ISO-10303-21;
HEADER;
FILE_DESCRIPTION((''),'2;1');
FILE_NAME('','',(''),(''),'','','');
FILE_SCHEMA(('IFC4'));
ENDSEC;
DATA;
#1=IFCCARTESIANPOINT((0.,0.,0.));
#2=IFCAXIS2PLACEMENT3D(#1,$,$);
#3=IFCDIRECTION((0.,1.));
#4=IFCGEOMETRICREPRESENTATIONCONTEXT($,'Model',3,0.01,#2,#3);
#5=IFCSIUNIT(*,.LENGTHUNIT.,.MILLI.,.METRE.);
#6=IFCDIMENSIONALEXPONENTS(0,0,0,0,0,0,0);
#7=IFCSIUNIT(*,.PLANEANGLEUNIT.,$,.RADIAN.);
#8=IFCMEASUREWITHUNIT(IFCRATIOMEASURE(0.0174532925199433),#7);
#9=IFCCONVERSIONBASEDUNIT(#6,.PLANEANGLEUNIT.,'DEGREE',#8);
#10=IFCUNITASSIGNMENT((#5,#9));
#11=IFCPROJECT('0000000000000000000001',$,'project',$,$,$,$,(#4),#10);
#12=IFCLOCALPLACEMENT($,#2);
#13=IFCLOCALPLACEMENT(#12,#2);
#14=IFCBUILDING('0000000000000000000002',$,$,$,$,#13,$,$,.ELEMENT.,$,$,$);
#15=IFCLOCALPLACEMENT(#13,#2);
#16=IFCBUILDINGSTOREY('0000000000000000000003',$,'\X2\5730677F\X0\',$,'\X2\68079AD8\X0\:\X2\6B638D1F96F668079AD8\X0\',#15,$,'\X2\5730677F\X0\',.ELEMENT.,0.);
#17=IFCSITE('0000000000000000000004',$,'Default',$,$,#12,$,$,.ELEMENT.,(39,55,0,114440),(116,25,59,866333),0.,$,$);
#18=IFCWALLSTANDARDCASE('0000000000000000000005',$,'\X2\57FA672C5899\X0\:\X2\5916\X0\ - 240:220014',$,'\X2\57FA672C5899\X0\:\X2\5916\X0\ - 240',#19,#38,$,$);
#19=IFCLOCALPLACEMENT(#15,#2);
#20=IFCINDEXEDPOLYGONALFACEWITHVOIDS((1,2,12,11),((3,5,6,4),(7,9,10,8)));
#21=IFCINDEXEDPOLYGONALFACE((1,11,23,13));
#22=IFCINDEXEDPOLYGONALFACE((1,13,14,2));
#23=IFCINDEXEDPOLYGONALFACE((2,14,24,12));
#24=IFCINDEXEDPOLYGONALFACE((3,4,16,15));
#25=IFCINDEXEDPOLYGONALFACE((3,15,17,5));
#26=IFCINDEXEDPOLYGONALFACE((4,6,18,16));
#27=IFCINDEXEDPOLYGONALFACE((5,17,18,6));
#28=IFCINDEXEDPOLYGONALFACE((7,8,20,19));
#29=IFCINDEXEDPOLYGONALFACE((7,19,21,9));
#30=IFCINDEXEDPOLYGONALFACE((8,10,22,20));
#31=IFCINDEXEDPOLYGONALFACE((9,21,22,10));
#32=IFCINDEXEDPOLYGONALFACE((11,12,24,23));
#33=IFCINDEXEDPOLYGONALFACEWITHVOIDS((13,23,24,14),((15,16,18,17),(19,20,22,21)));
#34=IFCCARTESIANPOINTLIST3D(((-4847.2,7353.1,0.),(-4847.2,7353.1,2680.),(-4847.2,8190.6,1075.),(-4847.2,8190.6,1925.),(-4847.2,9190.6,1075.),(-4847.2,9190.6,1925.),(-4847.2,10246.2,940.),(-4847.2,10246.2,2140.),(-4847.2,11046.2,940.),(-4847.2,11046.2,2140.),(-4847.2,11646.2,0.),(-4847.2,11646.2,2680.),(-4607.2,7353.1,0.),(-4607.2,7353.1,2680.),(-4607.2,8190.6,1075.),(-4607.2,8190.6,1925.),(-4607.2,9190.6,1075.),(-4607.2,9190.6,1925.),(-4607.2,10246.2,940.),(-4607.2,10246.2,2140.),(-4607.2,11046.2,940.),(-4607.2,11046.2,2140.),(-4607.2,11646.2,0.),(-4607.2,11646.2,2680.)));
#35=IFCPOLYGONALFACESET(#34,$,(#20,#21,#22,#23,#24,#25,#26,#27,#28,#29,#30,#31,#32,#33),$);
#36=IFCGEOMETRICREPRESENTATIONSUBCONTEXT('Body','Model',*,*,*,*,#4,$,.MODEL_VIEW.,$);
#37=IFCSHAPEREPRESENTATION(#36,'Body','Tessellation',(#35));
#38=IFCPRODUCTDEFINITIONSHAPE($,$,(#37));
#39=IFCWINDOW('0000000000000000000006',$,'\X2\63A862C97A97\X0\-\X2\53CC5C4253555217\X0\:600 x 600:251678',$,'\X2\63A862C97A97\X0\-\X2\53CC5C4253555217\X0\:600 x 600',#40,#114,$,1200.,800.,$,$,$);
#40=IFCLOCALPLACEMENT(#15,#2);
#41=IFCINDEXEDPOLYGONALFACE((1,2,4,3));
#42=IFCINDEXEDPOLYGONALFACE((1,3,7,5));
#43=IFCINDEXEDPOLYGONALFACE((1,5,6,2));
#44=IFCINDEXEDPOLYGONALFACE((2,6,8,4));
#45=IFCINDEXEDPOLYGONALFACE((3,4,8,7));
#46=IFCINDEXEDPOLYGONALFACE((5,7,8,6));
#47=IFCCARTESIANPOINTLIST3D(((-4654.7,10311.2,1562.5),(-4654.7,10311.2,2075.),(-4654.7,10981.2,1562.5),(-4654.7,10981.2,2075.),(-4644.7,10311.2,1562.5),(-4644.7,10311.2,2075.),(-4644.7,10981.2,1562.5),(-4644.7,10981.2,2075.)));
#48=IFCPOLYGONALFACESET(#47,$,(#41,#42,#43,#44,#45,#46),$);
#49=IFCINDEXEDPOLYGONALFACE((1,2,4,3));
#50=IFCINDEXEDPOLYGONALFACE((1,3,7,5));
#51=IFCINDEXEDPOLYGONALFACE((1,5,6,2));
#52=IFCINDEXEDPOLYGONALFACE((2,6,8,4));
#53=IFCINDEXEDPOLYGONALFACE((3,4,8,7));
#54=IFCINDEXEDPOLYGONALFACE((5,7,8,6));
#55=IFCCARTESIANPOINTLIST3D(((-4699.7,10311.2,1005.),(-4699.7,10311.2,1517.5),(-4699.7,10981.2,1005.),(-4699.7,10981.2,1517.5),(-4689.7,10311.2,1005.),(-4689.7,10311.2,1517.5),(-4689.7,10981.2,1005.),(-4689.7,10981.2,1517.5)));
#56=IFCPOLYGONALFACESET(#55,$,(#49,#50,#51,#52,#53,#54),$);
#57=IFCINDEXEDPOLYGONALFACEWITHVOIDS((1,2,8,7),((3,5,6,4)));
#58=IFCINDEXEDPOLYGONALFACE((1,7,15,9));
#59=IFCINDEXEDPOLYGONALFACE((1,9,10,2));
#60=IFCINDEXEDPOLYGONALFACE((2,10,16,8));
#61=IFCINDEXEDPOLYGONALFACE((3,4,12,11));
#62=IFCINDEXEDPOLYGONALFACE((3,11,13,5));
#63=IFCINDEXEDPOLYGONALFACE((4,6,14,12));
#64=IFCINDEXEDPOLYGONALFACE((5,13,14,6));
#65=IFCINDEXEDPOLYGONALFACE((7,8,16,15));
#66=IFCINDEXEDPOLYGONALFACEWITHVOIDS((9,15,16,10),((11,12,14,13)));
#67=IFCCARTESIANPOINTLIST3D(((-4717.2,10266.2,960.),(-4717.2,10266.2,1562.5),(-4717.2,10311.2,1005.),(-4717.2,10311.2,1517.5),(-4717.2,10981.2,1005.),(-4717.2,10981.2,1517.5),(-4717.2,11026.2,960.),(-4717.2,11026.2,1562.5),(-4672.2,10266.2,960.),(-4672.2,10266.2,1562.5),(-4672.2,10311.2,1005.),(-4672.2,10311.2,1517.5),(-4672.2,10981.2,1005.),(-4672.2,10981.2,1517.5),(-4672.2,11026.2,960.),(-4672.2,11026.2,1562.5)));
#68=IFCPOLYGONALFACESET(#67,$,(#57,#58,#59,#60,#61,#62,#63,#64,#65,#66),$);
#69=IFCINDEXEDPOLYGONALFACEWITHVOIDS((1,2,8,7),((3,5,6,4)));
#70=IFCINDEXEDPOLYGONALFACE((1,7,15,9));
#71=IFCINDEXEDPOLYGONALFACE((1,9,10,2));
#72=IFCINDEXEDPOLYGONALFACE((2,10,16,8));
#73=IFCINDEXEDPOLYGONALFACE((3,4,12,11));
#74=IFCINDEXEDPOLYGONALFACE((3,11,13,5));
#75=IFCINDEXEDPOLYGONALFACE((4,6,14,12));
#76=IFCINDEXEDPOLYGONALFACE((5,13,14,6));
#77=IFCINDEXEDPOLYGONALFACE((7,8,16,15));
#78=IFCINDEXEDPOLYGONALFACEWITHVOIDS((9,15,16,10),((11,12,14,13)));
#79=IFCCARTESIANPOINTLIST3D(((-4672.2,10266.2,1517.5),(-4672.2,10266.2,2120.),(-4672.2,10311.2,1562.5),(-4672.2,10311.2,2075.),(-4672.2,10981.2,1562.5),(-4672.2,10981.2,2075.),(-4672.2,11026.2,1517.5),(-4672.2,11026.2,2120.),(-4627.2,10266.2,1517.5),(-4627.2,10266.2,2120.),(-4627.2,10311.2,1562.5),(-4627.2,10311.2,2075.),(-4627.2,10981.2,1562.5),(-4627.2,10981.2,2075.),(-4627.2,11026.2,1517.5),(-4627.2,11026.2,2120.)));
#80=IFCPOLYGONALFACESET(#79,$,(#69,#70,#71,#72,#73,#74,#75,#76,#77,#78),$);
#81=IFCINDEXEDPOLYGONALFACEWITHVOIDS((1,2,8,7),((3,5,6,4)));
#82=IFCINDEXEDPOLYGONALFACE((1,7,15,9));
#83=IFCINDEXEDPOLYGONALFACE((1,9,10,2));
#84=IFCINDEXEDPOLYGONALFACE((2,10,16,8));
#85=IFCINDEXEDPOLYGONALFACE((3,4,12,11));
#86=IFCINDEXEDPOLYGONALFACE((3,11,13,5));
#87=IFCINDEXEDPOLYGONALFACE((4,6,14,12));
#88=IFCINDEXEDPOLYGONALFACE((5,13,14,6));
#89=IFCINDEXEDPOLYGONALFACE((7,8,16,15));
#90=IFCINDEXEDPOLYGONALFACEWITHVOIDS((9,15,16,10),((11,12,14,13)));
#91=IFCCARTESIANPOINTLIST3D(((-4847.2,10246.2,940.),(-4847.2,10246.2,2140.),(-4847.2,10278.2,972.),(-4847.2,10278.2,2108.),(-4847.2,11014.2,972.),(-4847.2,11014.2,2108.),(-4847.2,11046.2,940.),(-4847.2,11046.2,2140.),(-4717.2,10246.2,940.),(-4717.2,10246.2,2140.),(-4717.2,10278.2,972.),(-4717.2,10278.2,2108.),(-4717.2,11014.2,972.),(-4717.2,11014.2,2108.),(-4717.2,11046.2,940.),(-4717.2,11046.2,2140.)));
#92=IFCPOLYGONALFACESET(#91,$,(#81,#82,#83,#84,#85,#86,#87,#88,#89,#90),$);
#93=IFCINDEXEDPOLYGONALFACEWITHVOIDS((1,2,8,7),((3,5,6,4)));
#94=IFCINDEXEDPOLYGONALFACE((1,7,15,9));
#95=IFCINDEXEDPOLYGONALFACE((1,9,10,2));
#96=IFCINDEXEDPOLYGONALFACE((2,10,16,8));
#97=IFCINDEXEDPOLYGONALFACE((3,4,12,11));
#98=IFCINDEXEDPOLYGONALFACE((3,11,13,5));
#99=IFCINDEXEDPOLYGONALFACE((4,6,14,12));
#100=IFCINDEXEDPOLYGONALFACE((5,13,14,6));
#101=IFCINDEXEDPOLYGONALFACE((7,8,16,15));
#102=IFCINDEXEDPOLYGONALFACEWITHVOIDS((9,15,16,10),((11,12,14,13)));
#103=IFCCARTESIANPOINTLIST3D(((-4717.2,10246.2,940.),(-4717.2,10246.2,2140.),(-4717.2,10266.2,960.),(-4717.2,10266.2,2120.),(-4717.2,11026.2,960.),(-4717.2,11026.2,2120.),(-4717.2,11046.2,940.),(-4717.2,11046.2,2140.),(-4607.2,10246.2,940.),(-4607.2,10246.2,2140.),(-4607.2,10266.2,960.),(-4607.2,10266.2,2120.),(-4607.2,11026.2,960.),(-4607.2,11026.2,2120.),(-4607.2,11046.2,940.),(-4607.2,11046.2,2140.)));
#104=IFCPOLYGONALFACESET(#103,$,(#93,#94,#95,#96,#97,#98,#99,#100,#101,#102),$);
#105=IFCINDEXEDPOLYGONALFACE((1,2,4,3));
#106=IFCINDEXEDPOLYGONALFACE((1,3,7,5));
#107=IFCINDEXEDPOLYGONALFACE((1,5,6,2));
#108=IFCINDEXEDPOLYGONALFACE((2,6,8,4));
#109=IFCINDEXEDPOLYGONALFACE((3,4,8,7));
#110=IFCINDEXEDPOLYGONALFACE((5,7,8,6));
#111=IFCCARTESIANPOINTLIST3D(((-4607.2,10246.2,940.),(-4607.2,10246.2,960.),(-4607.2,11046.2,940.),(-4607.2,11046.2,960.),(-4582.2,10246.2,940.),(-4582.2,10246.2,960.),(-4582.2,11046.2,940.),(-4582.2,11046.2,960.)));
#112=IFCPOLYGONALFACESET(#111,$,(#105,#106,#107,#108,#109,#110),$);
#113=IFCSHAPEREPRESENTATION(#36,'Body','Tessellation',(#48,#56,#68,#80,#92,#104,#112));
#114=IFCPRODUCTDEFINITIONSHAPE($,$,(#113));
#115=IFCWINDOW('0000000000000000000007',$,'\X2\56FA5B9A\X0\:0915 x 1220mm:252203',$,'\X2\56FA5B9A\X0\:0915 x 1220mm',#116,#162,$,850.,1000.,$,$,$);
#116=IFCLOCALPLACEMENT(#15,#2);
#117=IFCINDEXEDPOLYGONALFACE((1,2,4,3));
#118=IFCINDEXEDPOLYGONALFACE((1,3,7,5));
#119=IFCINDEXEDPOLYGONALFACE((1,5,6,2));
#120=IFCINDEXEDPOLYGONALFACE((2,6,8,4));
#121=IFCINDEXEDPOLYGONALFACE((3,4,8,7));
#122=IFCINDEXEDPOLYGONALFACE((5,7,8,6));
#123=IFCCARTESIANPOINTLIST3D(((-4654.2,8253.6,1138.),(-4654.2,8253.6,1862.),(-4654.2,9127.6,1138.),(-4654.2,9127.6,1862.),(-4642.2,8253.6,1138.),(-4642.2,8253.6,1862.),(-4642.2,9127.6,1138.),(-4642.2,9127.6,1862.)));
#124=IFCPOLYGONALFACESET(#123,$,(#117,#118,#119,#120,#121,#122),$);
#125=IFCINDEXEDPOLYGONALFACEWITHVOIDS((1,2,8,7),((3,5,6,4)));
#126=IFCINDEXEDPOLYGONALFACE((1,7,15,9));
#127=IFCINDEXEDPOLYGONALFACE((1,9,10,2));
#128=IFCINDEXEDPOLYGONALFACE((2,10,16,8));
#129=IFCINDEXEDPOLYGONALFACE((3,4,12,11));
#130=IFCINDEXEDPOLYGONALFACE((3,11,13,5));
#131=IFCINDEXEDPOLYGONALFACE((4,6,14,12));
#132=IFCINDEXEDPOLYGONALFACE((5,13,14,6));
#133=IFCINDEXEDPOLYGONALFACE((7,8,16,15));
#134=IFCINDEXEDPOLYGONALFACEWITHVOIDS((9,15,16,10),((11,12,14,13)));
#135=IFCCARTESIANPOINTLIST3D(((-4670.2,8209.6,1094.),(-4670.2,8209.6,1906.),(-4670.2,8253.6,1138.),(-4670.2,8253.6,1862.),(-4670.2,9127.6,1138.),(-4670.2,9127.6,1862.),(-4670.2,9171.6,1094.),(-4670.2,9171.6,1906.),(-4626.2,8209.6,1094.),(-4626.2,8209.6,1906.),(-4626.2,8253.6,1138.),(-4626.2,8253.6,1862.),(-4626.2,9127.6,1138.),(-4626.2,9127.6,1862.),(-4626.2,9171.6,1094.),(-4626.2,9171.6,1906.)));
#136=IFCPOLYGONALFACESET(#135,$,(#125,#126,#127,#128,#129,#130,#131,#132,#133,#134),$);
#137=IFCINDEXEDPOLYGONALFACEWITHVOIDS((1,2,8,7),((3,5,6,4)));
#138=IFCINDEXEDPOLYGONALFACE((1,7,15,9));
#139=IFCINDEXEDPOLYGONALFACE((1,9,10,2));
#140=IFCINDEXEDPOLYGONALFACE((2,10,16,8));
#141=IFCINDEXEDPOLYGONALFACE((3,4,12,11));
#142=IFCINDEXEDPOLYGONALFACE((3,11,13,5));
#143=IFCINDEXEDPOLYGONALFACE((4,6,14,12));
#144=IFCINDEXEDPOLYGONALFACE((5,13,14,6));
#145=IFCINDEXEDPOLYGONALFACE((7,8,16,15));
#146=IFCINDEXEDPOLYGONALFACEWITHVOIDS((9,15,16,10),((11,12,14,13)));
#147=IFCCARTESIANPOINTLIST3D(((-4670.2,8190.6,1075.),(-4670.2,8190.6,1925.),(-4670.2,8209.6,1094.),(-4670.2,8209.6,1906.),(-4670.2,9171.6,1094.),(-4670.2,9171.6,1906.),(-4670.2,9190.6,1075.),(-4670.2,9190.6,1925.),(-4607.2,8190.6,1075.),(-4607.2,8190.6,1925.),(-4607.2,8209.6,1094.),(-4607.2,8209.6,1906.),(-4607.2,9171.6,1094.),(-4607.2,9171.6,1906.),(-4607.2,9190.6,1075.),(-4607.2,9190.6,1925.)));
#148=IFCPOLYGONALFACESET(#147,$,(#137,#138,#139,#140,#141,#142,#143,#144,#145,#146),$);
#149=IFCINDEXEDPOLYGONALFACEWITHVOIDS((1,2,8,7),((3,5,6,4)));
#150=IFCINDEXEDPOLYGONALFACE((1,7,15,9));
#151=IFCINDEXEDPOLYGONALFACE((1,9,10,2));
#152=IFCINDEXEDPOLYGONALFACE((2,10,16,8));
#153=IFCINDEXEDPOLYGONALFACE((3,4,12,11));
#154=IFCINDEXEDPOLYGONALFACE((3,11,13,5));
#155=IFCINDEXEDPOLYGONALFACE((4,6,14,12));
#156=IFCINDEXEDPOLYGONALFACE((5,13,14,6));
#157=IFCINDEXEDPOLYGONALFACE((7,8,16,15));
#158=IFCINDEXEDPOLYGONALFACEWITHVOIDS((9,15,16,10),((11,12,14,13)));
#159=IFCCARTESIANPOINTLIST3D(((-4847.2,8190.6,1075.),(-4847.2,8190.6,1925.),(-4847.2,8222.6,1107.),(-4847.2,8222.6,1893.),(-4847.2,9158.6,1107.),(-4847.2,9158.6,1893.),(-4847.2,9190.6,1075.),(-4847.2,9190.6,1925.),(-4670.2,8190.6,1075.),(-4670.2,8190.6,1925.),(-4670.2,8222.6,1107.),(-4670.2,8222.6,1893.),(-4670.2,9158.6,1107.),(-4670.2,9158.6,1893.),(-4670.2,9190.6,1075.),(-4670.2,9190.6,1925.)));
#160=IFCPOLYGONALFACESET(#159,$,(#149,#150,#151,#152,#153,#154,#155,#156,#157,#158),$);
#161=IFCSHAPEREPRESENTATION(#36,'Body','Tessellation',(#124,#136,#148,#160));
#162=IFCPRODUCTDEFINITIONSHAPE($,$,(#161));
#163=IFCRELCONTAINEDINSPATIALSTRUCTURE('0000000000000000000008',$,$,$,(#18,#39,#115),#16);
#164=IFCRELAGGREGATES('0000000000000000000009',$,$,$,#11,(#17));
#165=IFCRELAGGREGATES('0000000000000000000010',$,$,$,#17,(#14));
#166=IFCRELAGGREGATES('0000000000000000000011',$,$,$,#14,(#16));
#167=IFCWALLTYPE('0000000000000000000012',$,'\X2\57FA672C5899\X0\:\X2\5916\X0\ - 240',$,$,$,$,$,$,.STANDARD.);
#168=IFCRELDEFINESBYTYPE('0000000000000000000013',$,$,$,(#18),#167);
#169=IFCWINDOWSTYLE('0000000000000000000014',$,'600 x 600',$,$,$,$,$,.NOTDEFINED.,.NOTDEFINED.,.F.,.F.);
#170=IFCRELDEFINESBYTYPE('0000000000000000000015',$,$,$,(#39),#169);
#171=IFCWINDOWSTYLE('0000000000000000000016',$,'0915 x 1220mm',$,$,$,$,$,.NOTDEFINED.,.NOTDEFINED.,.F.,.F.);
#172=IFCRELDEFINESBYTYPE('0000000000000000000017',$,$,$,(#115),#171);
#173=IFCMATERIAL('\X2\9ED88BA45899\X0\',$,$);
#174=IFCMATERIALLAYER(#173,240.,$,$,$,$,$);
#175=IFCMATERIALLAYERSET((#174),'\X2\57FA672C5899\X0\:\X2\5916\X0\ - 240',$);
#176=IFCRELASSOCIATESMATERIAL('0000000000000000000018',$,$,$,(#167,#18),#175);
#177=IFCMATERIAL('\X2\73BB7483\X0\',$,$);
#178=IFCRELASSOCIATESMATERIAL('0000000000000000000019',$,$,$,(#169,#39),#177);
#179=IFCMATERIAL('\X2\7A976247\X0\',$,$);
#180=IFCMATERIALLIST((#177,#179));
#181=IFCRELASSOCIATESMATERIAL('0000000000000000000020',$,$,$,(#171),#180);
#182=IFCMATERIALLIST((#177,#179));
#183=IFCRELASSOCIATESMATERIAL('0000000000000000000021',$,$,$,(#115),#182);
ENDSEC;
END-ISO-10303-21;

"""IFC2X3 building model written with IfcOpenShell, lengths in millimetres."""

from ifc_helpers import new_model, entity, si_unit, converted_unit, direction, frame, frame_2d, origin, origin_2d_with_axis, place, context, subcontext, project, spatial, polyline, rectangle, outline, extrude, source, transform, mapped, material, material_list, layer, layer_set, layer_usage, type_object, type_shapes, element, fill, save


model = new_model("IFC2X3")

# Units and contexts
model_context = context("Model", 3, precision=0.01, world=origin(), true_north=direction((0.0, 1.0)))
body_context = subcontext(model_context, "Body", "Model", "MODEL_VIEW")
ifc_project = project(units=[si_unit("LENGTHUNIT", "METRE", prefix="MILLI"), converted_unit("PLANEANGLEUNIT", "DEGREE", entity("IfcRatioMeasure", 0.0174532925199433), si_unit("PLANEANGLEUNIT", "RADIAN"), dimensions=[0, 0, 0, 0, 0, 0, 0])], contexts=[model_context])

# Site, building, storey
site_placement = place(None, origin())
site = spatial("IfcSite", under=ifc_project, at=site_placement, Name="Default", CompositionType="ELEMENT", RefLatitude=(39, 55, 0, 114440), RefLongitude=(116, 25, 59, 866333), RefElevation=0.0)
building_placement = place(site_placement, origin())
building = spatial("IfcBuilding", under=site, at=building_placement, CompositionType="ELEMENT")
storey_placement = place(building_placement, origin())
storey = spatial("IfcBuildingStorey", under=building, at=storey_placement, Name="地板", ObjectType="标高:正负零标高", LongName="地板", CompositionType="ELEMENT", Elevation=0.0)

# Shared definitions
ifc_material_1 = material(Name="默认墙")
ifc_layer_1 = layer(ifc_material_1, 240.0)
ifc_layer_set_1 = layer_set([ifc_layer_1], Name="基本墙:外 - 240")
wall_type_1 = type_object("IfcWallType", Name="基本墙:外 - 240", PredefinedType="STANDARD", material=ifc_layer_set_1)
ifc_material_2 = material(Name="玻璃")
ifc_material_3 = material(Name="窗扇")

# Wall, openings, windows
ifc_layer_usage_1 = layer_usage(ifc_layer_set_1, "AXIS2", "NEGATIVE", 120.0)
wall_1_placement = place(storey_placement, frame((-4727.2, 7353.1, 0.0), z_axis=(0.0, 0.0, 1.0), x_axis=(0.0, 1.0, 0.0)))
wall_1 = element("IfcWallStandardCase", 1, at=wall_1_placement, inside=storey, type_object=wall_type_1, material=ifc_layer_usage_1, Name="基本墙:外 - 240:220014", ObjectType="基本墙:外 - 240", context=body_context, shape_type="SweptSolid", body=[
    extrude(rectangle(XDim=4293.1, YDim=240.0, at=frame_2d((2146.5, 0.0), x_axis=(-1.0, 0.0))), origin(), (0.0, 0.0, 1.0), 2680.0),
])
opening_1_placement = place(wall_1_placement, frame((3693.1, 120.0, 940.0)))
opening_1 = element("IfcOpeningElement", 2, at=opening_1_placement, cuts=wall_1, ObjectType="Opening", context=body_context, shape_type="SweptSolid", body=[
    extrude(rectangle(XDim=1200.0, YDim=800.0, at=frame_2d((600.0, 400.0), x_axis=(-1.0, 0.0))), frame((0.0, 0.0, 0.0), z_axis=(0.0, -1.0, 0.0), x_axis=(0.0, 0.0, 1.0)), (0.0, 0.0, 1.0), 240.0),
])
opening_2_placement = place(wall_1_placement, frame((1837.5, 120.0, 1075.0)))
opening_2 = element("IfcOpeningElement", 3, at=opening_2_placement, cuts=wall_1, ObjectType="Opening", context=body_context, shape_type="SweptSolid", body=[
    extrude(rectangle(XDim=850.0, YDim=1000.0, at=frame_2d((425.0, 500.0), x_axis=(1.0, 0.0))), frame((0.0, 0.0, 0.0), z_axis=(0.0, -1.0, 0.0), x_axis=(0.0, 0.0, 1.0)), (0.0, 0.0, 1.0), 240.0),
])
window_style_1 = type_object("IfcWindowStyle", Name="600 x 600", ConstructionType="NOTDEFINED", OperationType="NOTDEFINED", ParameterTakesPrecedence=False, Sizeable=False, material=ifc_material_2)
shared_shape_1 = source(origin(), body_context, "Body", "SweptSolid", [
    extrude(rectangle(XDim=10.0, YDim=670.0, at=origin_2d_with_axis()), frame((400.0, 197.5, 622.5), z_axis=(0.0, 0.0, 1.0), x_axis=(0.0, -1.0, 0.0)), (0.0, 0.0, 1.0), 512.5),
    extrude(rectangle(XDim=10.0, YDim=670.0, at=origin_2d_with_axis()), frame((400.0, 152.5, 65.0), z_axis=(0.0, 0.0, 1.0), x_axis=(0.0, -1.0, 0.0)), (0.0, 0.0, 1.0), 512.5),
    extrude(outline(polyline([(-380.0, -301.2), (380.0, -301.2), (380.0, 301.2), (-380.0, 301.2), (-380.0, -301.2)]), holes=[polyline([(-335.0, -256.2), (-335.0, 256.2), (335.0, 256.2), (335.0, -256.2), (-335.0, -256.2)])]), frame((400.0, 130.0, 321.3), z_axis=(0.0, 1.0, 0.0), x_axis=(1.0, 0.0, 0.0)), (0.0, 0.0, 1.0), 45.0),
    extrude(outline(polyline([(-380.0, -301.2), (380.0, -301.2), (380.0, 301.2), (-380.0, 301.2), (-380.0, -301.2)]), holes=[polyline([(-335.0, -256.2), (-335.0, 256.2), (335.0, 256.2), (335.0, -256.2), (-335.0, -256.2)])]), frame((400.0, 175.0, 878.8), z_axis=(0.0, 1.0, 0.0), x_axis=(1.0, 0.0, 0.0)), (0.0, 0.0, 1.0), 45.0),
    extrude(outline(polyline([(-400.0, -600.0), (400.0, -600.0), (400.0, 600.0), (-400.0, 600.0), (-400.0, -600.0)]), holes=[polyline([(-368.0, -568.0), (-368.0, 568.0), (368.0, 568.0), (368.0, -568.0), (-368.0, -568.0)])]), frame((400.0, 0.0, 600.0), z_axis=(0.0, 1.0, 0.0), x_axis=(1.0, 0.0, 0.0)), (0.0, 0.0, 1.0), 130.0),
    extrude(outline(polyline([(-600.0, -400.0), (600.0, -400.0), (600.0, 400.0), (-600.0, 400.0), (-600.0, -400.0)]), holes=[polyline([(-580.0, -380.0), (-580.0, 380.0), (580.0, 380.0), (580.0, -380.0), (-580.0, -380.0)])]), frame((400.0, 130.0, 600.0), z_axis=(0.0, 1.0, 0.0), x_axis=(0.0, 0.0, -1.0)), (0.0, 0.0, 1.0), 110.0),
    extrude(rectangle(XDim=25.0, YDim=800.0, at=origin_2d_with_axis()), frame((400.0, 252.5, 0.0), z_axis=(0.0, 0.0, 1.0), x_axis=(0.0, -1.0, 0.0)), (0.0, 0.0, 1.0), 20.0),
])
type_shapes(window_style_1, [shared_shape_1])
window_1_placement = place(opening_1_placement, frame((0.0, 0.0, 0.0), z_axis=(0.0, 0.0, 1.0), x_axis=(-1.0, 0.0, 0.0)))
window_1 = element("IfcWindow", 4, at=window_1_placement, inside=storey, type_object=window_style_1, material=ifc_material_2, Name="推拉窗-双层单列:600 x 600:251678", ObjectType="推拉窗-双层单列:600 x 600", OverallHeight=1200.0, OverallWidth=800.0, context=body_context, shape_type="MappedRepresentation", body=[
    mapped(shared_shape_1, transform((0.0, 0.0, 0.0), scale=1.0)),
])
fill(opening_1, window_1)
ifc_material_list_1 = material_list([ifc_material_2, ifc_material_3])
ifc_material_list_2 = material_list([ifc_material_2, ifc_material_3])
window_style_2 = type_object("IfcWindowStyle", Name="0915 x 1220mm", ConstructionType="NOTDEFINED", OperationType="NOTDEFINED", ParameterTakesPrecedence=False, Sizeable=False, material=ifc_material_list_2)
shared_shape_2 = source(origin(), body_context, "Body", "SweptSolid", [
    extrude(rectangle(XDim=12.0, YDim=874.0, at=frame_2d((0.0, 0.0), x_axis=(1.0, 0.0))), frame((500.0, 199.0, 63.0), z_axis=(0.0, 0.0, 1.0), x_axis=(0.0, -1.0, 0.0)), (0.0, 0.0, 1.0), 724.0),
    extrude(outline(polyline([(-481.0, -406.0), (481.0, -406.0), (481.0, 406.0), (-481.0, 406.0), (-481.0, -406.0)]), holes=[polyline([(-437.0, -362.0), (-437.0, 362.0), (437.0, 362.0), (437.0, -362.0), (-437.0, -362.0)])]), frame((500.0, 177.0, 425.0), z_axis=(0.0, 1.0, 0.0), x_axis=(1.0, 0.0, 0.0)), (0.0, 0.0, 1.0), 44.0),
    extrude(outline(polyline([(-500.0, -425.0), (500.0, -425.0), (500.0, 425.0), (-500.0, 425.0), (-500.0, -425.0)]), holes=[polyline([(-481.0, -406.0), (-481.0, 406.0), (481.0, 406.0), (481.0, -406.0), (-481.0, -406.0)])]), frame((500.0, 177.0, 425.0), z_axis=(0.0, 1.0, 0.0), x_axis=(1.0, 0.0, 0.0)), (0.0, 0.0, 1.0), 63.0),
    extrude(outline(polyline([(-500.0, -425.0), (500.0, -425.0), (500.0, 425.0), (-500.0, 425.0), (-500.0, -425.0)]), holes=[polyline([(-468.0, -393.0), (-468.0, 393.0), (468.0, 393.0), (468.0, -393.0), (-468.0, -393.0)])]), frame((500.0, 0.0, 425.0), z_axis=(0.0, 1.0, 0.0), x_axis=(1.0, 0.0, 0.0)), (0.0, 0.0, 1.0), 177.0),
])
type_shapes(window_style_2, [shared_shape_2])
window_2_placement = place(opening_2_placement, frame((0.0, 0.0, 0.0), z_axis=(0.0, 0.0, 1.0), x_axis=(-1.0, 0.0, 0.0)))
window_2 = element("IfcWindow", 5, at=window_2_placement, inside=storey, type_object=window_style_2, material=ifc_material_list_1, Name="固定:0915 x 1220mm:252203", ObjectType="固定:0915 x 1220mm", OverallHeight=850.0, OverallWidth=1000.0, context=body_context, shape_type="MappedRepresentation", body=[
    mapped(shared_shape_2, transform((0.0, 0.0, 0.0), scale=1.0)),
])
fill(opening_2, window_2)

save(model, "model.ifc")
